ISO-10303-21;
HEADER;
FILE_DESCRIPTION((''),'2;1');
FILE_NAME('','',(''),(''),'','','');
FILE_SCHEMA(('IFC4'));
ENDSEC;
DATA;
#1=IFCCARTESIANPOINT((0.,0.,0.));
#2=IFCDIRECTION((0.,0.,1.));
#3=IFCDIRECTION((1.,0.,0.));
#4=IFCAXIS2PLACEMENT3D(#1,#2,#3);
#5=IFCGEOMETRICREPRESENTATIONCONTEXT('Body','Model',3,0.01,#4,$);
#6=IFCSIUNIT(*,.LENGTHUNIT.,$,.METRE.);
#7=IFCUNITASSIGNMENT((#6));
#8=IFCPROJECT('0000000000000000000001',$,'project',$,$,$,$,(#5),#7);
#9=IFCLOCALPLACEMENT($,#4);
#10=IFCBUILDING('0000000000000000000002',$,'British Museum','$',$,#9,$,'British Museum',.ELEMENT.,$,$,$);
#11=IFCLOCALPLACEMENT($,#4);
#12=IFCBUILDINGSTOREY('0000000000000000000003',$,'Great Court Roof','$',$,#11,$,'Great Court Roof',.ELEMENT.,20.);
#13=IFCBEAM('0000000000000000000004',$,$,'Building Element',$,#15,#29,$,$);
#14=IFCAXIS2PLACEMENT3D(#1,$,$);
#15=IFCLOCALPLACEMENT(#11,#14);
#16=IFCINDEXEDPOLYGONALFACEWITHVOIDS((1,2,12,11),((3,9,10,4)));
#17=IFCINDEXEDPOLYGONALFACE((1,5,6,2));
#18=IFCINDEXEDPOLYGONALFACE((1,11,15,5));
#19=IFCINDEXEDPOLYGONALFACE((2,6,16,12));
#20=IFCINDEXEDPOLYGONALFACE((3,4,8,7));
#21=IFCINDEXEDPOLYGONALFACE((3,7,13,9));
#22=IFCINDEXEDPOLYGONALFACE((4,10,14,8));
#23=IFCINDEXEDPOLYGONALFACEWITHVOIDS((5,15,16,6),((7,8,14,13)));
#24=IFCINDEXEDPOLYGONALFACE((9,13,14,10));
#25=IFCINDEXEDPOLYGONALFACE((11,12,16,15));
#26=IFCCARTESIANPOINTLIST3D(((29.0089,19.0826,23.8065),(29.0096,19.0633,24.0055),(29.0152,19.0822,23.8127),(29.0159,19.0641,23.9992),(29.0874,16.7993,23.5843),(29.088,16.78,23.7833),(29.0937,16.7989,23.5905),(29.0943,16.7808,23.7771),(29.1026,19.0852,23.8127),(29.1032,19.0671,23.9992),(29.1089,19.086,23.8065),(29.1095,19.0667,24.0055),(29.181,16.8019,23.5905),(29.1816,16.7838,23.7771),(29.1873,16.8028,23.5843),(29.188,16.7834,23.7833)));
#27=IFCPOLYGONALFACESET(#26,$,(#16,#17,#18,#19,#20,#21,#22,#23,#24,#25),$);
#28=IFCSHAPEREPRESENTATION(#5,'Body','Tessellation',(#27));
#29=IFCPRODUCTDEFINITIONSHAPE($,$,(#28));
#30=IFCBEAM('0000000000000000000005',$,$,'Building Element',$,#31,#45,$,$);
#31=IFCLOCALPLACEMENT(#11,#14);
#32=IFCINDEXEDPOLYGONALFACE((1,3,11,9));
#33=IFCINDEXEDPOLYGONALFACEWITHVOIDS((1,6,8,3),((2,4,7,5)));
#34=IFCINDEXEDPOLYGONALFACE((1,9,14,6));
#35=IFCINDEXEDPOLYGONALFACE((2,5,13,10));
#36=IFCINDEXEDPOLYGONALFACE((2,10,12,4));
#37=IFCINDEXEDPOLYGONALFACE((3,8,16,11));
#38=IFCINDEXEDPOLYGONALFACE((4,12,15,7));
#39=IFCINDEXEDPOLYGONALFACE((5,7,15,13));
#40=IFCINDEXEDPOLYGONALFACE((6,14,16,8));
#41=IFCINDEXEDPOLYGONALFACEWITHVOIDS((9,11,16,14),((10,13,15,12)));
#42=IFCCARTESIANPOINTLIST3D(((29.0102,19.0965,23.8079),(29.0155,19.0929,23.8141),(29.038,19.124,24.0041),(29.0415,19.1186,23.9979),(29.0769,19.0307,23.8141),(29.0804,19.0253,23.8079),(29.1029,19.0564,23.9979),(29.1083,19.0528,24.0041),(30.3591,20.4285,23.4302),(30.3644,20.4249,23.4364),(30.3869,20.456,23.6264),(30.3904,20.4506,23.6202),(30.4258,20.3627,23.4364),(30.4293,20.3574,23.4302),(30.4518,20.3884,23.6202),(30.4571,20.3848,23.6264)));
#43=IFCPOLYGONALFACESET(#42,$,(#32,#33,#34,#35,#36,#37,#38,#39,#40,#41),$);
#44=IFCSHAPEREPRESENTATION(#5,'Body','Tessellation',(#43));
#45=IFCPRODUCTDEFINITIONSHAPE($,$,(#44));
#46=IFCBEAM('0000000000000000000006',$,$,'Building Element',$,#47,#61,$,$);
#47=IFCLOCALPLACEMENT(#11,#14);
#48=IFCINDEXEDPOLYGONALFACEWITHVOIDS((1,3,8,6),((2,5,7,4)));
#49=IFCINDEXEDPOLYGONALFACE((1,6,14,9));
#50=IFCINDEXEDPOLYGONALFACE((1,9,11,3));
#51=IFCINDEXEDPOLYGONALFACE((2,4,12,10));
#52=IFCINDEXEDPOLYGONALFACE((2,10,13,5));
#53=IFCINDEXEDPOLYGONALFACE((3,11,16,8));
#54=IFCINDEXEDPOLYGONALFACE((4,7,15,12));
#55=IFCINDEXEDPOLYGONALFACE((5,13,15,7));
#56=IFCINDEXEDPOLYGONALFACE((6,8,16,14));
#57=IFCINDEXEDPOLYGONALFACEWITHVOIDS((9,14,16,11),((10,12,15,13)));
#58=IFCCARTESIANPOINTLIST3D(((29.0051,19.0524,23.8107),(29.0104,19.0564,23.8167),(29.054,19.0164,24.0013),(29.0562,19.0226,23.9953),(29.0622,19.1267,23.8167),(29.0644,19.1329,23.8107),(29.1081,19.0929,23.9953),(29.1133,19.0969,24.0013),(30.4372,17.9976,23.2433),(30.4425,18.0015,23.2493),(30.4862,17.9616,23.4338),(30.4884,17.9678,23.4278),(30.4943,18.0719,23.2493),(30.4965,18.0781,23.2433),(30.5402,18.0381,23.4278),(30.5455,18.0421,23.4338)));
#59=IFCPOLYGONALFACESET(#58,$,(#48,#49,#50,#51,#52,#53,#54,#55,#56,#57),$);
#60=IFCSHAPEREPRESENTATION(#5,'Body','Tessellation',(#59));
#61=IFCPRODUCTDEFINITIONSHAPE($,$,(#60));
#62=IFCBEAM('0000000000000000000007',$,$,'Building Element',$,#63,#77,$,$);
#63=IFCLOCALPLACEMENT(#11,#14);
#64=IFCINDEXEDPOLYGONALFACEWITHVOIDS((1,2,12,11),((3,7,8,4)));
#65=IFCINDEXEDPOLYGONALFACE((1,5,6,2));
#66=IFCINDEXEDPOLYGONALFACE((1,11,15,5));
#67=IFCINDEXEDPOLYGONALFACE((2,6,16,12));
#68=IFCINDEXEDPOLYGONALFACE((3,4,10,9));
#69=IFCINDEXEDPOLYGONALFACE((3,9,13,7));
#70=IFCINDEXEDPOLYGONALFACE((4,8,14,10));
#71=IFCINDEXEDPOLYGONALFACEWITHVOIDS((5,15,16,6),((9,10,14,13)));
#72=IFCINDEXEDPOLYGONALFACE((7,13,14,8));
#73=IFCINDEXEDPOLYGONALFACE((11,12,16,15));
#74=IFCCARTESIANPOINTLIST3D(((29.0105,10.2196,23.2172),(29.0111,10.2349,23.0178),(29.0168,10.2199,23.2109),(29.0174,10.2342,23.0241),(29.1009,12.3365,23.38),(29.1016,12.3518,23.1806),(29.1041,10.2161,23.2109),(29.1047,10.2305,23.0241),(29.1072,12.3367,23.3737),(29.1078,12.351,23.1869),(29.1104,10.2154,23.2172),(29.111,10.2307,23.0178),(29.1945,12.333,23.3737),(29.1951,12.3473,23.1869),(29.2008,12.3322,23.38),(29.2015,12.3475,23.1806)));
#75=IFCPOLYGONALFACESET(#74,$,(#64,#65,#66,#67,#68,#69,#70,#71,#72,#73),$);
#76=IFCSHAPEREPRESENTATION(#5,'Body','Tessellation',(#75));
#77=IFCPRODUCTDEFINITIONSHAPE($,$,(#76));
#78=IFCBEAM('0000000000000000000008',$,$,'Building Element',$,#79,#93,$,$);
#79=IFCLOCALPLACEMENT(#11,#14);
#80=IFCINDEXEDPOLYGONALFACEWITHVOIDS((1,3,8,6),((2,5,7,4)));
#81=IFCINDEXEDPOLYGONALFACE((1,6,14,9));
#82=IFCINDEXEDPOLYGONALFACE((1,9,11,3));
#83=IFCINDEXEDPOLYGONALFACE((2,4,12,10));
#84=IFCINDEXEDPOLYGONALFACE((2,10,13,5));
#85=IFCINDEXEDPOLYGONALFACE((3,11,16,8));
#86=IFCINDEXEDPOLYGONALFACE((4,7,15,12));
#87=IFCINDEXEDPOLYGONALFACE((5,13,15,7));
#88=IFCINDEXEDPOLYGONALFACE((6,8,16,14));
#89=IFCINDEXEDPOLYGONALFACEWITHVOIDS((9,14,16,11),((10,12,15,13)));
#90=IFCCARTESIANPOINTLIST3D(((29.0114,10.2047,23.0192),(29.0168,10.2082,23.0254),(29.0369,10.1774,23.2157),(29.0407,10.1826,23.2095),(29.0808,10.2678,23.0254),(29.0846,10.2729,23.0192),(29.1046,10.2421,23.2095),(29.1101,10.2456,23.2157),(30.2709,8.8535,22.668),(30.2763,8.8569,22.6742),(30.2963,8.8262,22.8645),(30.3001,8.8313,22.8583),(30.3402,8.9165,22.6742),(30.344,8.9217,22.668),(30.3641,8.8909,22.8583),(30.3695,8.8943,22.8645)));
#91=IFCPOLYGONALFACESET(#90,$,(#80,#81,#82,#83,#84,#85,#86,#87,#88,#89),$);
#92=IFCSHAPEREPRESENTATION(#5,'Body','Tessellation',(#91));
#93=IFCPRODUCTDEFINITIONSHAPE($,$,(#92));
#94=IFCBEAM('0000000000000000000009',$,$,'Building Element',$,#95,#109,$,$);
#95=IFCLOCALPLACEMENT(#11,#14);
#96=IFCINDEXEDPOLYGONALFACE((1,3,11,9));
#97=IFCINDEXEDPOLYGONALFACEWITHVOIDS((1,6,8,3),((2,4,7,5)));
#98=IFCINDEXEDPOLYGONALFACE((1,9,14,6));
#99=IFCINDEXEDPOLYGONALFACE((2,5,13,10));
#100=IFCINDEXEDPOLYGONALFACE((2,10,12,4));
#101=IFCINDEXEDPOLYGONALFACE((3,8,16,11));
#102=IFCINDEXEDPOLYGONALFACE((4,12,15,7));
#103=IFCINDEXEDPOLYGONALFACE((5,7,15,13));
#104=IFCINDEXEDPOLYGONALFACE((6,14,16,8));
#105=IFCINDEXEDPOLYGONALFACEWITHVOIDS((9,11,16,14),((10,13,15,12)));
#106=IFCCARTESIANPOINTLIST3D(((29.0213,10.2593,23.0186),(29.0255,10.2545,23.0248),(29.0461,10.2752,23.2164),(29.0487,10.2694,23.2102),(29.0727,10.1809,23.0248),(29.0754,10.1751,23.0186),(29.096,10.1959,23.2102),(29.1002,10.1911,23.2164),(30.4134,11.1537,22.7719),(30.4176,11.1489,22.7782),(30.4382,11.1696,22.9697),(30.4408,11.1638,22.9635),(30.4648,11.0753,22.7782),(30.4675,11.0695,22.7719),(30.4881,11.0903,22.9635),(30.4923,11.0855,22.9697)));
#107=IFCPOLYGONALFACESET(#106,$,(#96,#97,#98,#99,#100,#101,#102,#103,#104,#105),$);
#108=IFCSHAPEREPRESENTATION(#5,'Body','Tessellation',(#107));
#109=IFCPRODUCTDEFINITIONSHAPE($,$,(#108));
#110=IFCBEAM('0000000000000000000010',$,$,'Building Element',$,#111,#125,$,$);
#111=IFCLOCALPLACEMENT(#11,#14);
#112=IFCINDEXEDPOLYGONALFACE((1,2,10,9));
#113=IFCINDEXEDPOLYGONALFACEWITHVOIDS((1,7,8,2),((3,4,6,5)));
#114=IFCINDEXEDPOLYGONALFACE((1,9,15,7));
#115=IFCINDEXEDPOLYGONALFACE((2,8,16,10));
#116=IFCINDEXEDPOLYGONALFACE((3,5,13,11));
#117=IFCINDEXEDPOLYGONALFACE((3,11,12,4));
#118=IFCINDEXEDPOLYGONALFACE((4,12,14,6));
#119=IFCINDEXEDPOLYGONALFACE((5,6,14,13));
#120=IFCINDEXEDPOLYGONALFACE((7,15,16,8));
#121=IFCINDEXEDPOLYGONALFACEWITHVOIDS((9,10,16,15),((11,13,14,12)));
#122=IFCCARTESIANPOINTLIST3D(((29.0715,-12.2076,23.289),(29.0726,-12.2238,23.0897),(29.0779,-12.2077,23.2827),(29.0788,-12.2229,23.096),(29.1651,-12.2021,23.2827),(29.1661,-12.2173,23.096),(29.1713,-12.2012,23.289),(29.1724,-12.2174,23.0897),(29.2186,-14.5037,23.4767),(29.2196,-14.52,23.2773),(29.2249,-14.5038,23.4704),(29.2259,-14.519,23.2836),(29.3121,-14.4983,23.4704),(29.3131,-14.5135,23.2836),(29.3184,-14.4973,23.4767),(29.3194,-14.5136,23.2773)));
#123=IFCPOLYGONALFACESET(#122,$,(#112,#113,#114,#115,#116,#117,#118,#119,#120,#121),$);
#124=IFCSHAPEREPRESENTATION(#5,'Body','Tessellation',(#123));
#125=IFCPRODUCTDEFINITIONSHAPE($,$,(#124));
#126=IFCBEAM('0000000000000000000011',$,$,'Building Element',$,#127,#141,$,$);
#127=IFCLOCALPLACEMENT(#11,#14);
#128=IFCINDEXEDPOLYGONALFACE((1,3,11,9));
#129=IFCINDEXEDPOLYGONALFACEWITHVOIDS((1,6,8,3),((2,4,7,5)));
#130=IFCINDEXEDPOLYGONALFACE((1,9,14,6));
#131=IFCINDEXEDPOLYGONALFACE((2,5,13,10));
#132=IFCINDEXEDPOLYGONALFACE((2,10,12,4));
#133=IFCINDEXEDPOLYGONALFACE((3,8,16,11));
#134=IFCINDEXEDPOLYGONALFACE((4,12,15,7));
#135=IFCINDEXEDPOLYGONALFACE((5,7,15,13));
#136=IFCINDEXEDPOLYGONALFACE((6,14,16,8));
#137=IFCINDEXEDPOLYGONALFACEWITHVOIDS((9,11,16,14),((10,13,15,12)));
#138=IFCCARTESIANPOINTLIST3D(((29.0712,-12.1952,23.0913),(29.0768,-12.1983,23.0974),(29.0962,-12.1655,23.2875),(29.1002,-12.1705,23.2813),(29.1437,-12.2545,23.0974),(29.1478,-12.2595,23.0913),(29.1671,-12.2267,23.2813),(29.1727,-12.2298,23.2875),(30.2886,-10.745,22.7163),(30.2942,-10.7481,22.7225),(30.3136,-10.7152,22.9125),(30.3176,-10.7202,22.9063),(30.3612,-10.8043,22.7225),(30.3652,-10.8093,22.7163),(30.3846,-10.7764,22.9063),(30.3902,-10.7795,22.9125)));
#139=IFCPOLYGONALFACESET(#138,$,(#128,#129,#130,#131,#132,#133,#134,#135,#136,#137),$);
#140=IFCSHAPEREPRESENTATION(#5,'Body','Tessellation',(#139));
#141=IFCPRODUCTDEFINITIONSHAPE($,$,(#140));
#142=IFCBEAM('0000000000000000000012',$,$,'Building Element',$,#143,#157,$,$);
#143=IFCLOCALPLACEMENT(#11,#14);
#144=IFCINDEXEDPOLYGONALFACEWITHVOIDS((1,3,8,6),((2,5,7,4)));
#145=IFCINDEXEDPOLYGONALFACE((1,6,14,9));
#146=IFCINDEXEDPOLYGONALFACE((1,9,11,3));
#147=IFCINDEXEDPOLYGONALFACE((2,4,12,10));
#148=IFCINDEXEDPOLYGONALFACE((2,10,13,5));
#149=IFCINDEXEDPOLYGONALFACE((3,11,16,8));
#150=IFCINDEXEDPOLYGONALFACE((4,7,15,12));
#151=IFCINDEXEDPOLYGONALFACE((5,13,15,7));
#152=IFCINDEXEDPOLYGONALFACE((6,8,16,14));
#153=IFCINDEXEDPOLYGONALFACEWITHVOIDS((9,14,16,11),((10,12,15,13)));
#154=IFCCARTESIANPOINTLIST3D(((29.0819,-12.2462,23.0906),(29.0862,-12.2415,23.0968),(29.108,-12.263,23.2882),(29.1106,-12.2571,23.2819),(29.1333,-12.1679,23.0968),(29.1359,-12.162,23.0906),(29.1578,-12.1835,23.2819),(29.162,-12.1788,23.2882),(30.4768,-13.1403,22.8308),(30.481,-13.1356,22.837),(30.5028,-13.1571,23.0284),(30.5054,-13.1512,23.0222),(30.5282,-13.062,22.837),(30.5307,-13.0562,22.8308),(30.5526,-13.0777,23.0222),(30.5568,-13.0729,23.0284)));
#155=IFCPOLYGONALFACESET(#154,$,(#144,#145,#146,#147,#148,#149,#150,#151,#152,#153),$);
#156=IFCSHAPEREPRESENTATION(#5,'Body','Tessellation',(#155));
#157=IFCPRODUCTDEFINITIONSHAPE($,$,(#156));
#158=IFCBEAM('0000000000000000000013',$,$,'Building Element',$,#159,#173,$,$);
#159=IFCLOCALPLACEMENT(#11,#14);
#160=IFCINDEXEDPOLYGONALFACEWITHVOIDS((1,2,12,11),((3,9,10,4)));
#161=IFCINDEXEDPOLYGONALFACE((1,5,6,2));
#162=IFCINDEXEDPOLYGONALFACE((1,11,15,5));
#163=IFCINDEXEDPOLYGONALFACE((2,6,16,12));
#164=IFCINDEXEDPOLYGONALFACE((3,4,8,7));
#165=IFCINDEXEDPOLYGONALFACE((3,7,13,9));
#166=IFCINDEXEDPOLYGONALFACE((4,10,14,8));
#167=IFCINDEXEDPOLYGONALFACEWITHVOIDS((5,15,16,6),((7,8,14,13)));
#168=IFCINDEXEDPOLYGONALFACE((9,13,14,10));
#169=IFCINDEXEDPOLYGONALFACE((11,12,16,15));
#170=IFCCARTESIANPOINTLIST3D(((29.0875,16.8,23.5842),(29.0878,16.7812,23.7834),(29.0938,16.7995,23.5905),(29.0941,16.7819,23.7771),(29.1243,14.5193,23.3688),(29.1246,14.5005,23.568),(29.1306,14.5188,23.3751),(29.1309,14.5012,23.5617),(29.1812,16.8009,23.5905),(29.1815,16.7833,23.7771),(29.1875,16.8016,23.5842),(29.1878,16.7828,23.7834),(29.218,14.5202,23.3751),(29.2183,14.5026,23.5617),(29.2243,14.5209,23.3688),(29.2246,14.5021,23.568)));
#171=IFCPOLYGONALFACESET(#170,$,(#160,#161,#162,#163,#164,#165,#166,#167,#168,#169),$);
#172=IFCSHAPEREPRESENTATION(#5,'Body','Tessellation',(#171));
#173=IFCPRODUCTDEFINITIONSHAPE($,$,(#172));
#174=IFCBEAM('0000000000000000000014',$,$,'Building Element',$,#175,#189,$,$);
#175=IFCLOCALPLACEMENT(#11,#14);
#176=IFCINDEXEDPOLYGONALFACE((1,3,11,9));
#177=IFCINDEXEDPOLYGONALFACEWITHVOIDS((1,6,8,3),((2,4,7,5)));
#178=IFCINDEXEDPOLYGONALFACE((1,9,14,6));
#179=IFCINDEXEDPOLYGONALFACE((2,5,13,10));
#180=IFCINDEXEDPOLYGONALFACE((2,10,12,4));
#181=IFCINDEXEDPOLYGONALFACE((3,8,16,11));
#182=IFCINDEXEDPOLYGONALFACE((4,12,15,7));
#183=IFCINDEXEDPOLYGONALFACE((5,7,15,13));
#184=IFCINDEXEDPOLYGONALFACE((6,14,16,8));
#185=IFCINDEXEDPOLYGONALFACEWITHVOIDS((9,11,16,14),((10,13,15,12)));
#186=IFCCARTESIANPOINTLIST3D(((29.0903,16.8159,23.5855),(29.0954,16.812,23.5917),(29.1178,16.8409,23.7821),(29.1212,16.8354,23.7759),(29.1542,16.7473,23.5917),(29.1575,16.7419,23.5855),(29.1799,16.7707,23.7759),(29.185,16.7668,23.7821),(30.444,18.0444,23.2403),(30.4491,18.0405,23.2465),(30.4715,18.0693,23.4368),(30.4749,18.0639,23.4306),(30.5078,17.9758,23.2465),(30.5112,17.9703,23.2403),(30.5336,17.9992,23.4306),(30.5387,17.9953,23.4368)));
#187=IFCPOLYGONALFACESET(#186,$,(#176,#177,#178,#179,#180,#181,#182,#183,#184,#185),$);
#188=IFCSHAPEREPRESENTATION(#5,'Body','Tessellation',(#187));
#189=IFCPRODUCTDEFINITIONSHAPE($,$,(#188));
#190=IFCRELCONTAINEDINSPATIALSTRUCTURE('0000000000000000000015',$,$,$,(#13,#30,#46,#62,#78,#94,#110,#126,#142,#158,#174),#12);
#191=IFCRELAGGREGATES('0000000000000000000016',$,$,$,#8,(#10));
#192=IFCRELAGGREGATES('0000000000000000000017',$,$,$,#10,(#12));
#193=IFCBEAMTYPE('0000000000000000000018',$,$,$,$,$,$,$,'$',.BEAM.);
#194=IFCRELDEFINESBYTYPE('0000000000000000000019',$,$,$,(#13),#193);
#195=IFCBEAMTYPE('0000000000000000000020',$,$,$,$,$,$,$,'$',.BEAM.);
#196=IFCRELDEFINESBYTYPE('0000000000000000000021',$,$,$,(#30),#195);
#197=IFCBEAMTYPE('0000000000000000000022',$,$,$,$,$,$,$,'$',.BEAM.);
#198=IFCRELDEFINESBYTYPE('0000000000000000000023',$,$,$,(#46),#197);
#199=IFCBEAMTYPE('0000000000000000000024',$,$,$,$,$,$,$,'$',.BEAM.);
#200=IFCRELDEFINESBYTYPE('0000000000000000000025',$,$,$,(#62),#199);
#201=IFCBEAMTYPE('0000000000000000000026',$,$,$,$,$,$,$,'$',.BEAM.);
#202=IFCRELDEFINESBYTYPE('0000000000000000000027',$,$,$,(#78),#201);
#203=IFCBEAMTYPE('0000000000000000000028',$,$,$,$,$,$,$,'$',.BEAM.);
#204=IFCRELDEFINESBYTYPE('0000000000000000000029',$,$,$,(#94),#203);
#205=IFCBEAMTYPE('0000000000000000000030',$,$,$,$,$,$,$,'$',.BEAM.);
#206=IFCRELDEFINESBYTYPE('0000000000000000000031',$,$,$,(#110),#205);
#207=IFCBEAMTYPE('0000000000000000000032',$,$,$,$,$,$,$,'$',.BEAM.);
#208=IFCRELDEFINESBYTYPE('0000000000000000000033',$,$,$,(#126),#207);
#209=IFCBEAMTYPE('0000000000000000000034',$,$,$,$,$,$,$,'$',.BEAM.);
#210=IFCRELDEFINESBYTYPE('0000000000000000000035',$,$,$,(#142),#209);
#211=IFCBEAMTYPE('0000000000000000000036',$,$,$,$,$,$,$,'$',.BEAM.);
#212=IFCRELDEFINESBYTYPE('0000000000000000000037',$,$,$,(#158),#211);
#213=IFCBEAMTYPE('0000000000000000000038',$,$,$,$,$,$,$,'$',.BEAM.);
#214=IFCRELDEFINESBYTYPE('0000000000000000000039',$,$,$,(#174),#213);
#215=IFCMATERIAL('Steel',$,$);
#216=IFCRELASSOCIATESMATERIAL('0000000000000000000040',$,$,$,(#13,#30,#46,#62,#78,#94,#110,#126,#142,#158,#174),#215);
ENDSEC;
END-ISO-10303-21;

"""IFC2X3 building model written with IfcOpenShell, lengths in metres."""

from ifc_helpers import new_model, si_unit, frame, origin_with_axes, origin_2d, place, context, project, spatial, hollow_rectangle, extrude, material, type_object, element, save


model = new_model("IFC2X3")

# Units and contexts
model_context = context("Model", 3, precision=0.01, world=origin_with_axes(), identifier="Body")
ifc_project = project(units=[si_unit("LENGTHUNIT", "METRE")], contexts=[model_context])

# Building, storey
building_placement = place(None, origin_with_axes())
building = spatial("IfcBuilding", under=ifc_project, at=building_placement, Name="British Museum", Description="$", LongName="British Museum", CompositionType="ELEMENT")
storey_placement = place(None, origin_with_axes())
storey = spatial("IfcBuildingStorey", under=building, at=storey_placement, Name="Great Court Roof", Description="$", LongName="Great Court Roof", CompositionType="ELEMENT", Elevation=20.0)

# Beams
ifc_material = material(Name="Steel")
beam_type_1 = type_object("IfcBeamType", ElementType="$", PredefinedType="BEAM")
beam_1_placement = place(None, origin_with_axes())
element("IfcBeam", 1, at=beam_1_placement, inside=storey, type_object=beam_type_1, material=ifc_material, Description="Building Element", context=model_context, shape_type="SweptSolid", body=[
    extrude(hollow_rectangle(XDim=0.1, YDim=0.2, WallThickness=0.0063, InnerFilletRadius=-0.0063, OuterFilletRadius=0.0, at=origin_2d()), frame((29.0592, 19.0746, 23.906), z_axis=(0.034175, -0.994717, -0.096798), x_axis=(0.99941, 0.034337, 0.0)), (0.0, 0.0, 1.0), 2.2954),
])
beam_type_2 = type_object("IfcBeamType", ElementType="$", PredefinedType="BEAM")
beam_2_placement = place(None, origin_with_axes())
element("IfcBeam", 2, at=beam_2_placement, inside=storey, type_object=beam_type_2, material=ifc_material, Description="Building Element", context=model_context, shape_type="SweptSolid", body=[
    extrude(hollow_rectangle(XDim=0.1, YDim=0.2, WallThickness=0.0063, InnerFilletRadius=-0.0063, OuterFilletRadius=0.0, at=origin_2d()), frame((29.0592, 19.0746, 23.906), z_axis=(0.697823, 0.689107, -0.195382), x_axis=(-0.702649, 0.711537, 0.0)), (0.0, 0.0, 1.0), 1.933),
])
beam_type_3 = type_object("IfcBeamType", ElementType="$", PredefinedType="BEAM")
beam_3_placement = place(None, origin_with_axes())
element("IfcBeam", 3, at=beam_3_placement, inside=storey, type_object=beam_type_3, material=ifc_material, Description="Building Element", context=model_context, shape_type="SweptSolid", body=[
    extrude(hollow_rectangle(XDim=0.1, YDim=0.2, WallThickness=0.0063, InnerFilletRadius=-0.0063, OuterFilletRadius=0.0, at=origin_2d()), frame((29.0592, 19.0746, 23.906), z_axis=(0.767082, -0.564983, -0.303939), x_axis=(0.593039, 0.805174, 0.0)), (0.0, 0.0, 1.0), 1.867),
])
beam_type_4 = type_object("IfcBeamType", ElementType="$", PredefinedType="BEAM")
beam_4_placement = place(None, origin_with_axes())
element("IfcBeam", 4, at=beam_4_placement, inside=storey, type_object=beam_type_4, material=ifc_material, Description="Building Element", context=model_context, shape_type="SweptSolid", body=[
    extrude(hollow_rectangle(XDim=0.1, YDim=0.2, WallThickness=0.0063, InnerFilletRadius=-0.0063, OuterFilletRadius=0.0, at=origin_2d()), frame((29.0607, 10.2252, 23.1175), z_axis=(0.042557, 0.996153, 0.07661), x_axis=(-0.999089, 0.042682, 0.0)), (0.0, 0.0, 1.0), 2.125),
])
beam_type_5 = type_object("IfcBeamType", ElementType="$", PredefinedType="BEAM")
beam_5_placement = place(None, origin_with_axes())
element("IfcBeam", 5, at=beam_5_placement, inside=storey, type_object=beam_type_5, material=ifc_material, Description="Building Element", context=model_context, shape_type="SweptSolid", body=[
    extrude(hollow_rectangle(XDim=0.1, YDim=0.2, WallThickness=0.0063, InnerFilletRadius=-0.0063, OuterFilletRadius=0.0, at=origin_2d()), frame((29.0607, 10.2252, 23.1175), z_axis=(0.669817, -0.718646, -0.186797), x_axis=(0.731522, 0.681818, 0.0)), (0.0, 0.0, 1.0), 1.8803),
])
beam_type_6 = type_object("IfcBeamType", ElementType="$", PredefinedType="BEAM")
beam_6_placement = place(None, origin_with_axes())
element("IfcBeam", 6, at=beam_6_placement, inside=storey, type_object=beam_type_6, material=ifc_material, Description="Building Element", context=model_context, shape_type="SweptSolid", body=[
    extrude(hollow_rectangle(XDim=0.1, YDim=0.2, WallThickness=0.0063, InnerFilletRadius=-0.0063, OuterFilletRadius=0.0, at=origin_2d()), frame((29.0607, 10.2252, 23.1175), z_axis=(0.832126, 0.53463, -0.147436), x_axis=(-0.540537, 0.84132, 0.0)), (0.0, 0.0, 1.0), 1.6729),
])
beam_type_7 = type_object("IfcBeamType", ElementType="$", PredefinedType="BEAM")
beam_7_placement = place(None, origin_with_axes())
element("IfcBeam", 7, at=beam_7_placement, inside=storey, type_object=beam_type_7, material=ifc_material, Description="Building Element", context=model_context, shape_type="SweptSolid", body=[
    extrude(hollow_rectangle(XDim=0.1, YDim=0.2, WallThickness=0.0063, InnerFilletRadius=-0.0063, OuterFilletRadius=0.0, at=origin_2d()), frame((29.122, -12.2125, 23.1894), z_axis=(0.063696, -0.994654, 0.08128), x_axis=(0.997956, 0.063907, 0.0)), (0.0, 0.0, 1.0), 2.3085),
])
beam_type_8 = type_object("IfcBeamType", ElementType="$", PredefinedType="BEAM")
beam_8_placement = place(None, origin_with_axes())
element("IfcBeam", 8, at=beam_8_placement, inside=storey, type_object=beam_type_8, material=ifc_material, Description="Building Element", context=model_context, shape_type="SweptSolid", body=[
    extrude(hollow_rectangle(XDim=0.1, YDim=0.2, WallThickness=0.0063, InnerFilletRadius=-0.0063, OuterFilletRadius=0.0, at=origin_2d()), frame((29.122, -12.2125, 23.1894), z_axis=(0.630716, 0.751307, -0.194254), x_axis=(-0.765897, 0.642964, 0.0)), (0.0, 0.0, 1.0), 1.9303),
])
beam_type_9 = type_object("IfcBeamType", ElementType="$", PredefinedType="BEAM")
beam_9_placement = place(None, origin_with_axes())
element("IfcBeam", 9, at=beam_9_placement, inside=storey, type_object=beam_type_9, material=ifc_material, Description="Building Element", context=model_context, shape_type="SweptSolid", body=[
    extrude(hollow_rectangle(XDim=0.1, YDim=0.2, WallThickness=0.0063, InnerFilletRadius=-0.0063, OuterFilletRadius=0.0, at=origin_2d()), frame((29.122, -12.2125, 23.1894), z_axis=(0.831723, -0.533145, -0.154899), x_axis=(0.539658, 0.841884, 0.0)), (0.0, 0.0, 1.0), 1.677),
])
beam_type_10 = type_object("IfcBeamType", ElementType="$", PredefinedType="BEAM")
beam_10_placement = place(None, origin_with_axes())
element("IfcBeam", 10, at=beam_10_placement, inside=storey, type_object=beam_type_10, material=ifc_material, Description="Building Element", context=model_context, shape_type="SweptSolid", body=[
    extrude(hollow_rectangle(XDim=0.1, YDim=0.2, WallThickness=0.0063, InnerFilletRadius=-0.0063, OuterFilletRadius=0.0, at=origin_2d()), frame((29.1377, 16.7914, 23.6838), z_axis=(0.016061, -0.995441, -0.094013), x_axis=(0.99987, 0.016133, 0.0)), (0.0, 0.0, 1.0), 2.2911),
])
beam_type_11 = type_object("IfcBeamType", ElementType="$", PredefinedType="BEAM")
beam_11_placement = place(None, origin_with_axes())
element("IfcBeam", 11, at=beam_11_placement, inside=storey, type_object=beam_type_11, material=ifc_material, Description="Building Element", context=model_context, shape_type="SweptSolid", body=[
    extrude(hollow_rectangle(XDim=0.1, YDim=0.2, WallThickness=0.0063, InnerFilletRadius=-0.0063, OuterFilletRadius=0.0, at=origin_2d()), frame((29.1377, 16.7914, 23.6838), z_axis=(0.727661, 0.660352, -0.185591), x_axis=(-0.672027, 0.740526, 0.0)), (0.0, 0.0, 1.0), 1.8603),
])

save(model, "model.ifc")
